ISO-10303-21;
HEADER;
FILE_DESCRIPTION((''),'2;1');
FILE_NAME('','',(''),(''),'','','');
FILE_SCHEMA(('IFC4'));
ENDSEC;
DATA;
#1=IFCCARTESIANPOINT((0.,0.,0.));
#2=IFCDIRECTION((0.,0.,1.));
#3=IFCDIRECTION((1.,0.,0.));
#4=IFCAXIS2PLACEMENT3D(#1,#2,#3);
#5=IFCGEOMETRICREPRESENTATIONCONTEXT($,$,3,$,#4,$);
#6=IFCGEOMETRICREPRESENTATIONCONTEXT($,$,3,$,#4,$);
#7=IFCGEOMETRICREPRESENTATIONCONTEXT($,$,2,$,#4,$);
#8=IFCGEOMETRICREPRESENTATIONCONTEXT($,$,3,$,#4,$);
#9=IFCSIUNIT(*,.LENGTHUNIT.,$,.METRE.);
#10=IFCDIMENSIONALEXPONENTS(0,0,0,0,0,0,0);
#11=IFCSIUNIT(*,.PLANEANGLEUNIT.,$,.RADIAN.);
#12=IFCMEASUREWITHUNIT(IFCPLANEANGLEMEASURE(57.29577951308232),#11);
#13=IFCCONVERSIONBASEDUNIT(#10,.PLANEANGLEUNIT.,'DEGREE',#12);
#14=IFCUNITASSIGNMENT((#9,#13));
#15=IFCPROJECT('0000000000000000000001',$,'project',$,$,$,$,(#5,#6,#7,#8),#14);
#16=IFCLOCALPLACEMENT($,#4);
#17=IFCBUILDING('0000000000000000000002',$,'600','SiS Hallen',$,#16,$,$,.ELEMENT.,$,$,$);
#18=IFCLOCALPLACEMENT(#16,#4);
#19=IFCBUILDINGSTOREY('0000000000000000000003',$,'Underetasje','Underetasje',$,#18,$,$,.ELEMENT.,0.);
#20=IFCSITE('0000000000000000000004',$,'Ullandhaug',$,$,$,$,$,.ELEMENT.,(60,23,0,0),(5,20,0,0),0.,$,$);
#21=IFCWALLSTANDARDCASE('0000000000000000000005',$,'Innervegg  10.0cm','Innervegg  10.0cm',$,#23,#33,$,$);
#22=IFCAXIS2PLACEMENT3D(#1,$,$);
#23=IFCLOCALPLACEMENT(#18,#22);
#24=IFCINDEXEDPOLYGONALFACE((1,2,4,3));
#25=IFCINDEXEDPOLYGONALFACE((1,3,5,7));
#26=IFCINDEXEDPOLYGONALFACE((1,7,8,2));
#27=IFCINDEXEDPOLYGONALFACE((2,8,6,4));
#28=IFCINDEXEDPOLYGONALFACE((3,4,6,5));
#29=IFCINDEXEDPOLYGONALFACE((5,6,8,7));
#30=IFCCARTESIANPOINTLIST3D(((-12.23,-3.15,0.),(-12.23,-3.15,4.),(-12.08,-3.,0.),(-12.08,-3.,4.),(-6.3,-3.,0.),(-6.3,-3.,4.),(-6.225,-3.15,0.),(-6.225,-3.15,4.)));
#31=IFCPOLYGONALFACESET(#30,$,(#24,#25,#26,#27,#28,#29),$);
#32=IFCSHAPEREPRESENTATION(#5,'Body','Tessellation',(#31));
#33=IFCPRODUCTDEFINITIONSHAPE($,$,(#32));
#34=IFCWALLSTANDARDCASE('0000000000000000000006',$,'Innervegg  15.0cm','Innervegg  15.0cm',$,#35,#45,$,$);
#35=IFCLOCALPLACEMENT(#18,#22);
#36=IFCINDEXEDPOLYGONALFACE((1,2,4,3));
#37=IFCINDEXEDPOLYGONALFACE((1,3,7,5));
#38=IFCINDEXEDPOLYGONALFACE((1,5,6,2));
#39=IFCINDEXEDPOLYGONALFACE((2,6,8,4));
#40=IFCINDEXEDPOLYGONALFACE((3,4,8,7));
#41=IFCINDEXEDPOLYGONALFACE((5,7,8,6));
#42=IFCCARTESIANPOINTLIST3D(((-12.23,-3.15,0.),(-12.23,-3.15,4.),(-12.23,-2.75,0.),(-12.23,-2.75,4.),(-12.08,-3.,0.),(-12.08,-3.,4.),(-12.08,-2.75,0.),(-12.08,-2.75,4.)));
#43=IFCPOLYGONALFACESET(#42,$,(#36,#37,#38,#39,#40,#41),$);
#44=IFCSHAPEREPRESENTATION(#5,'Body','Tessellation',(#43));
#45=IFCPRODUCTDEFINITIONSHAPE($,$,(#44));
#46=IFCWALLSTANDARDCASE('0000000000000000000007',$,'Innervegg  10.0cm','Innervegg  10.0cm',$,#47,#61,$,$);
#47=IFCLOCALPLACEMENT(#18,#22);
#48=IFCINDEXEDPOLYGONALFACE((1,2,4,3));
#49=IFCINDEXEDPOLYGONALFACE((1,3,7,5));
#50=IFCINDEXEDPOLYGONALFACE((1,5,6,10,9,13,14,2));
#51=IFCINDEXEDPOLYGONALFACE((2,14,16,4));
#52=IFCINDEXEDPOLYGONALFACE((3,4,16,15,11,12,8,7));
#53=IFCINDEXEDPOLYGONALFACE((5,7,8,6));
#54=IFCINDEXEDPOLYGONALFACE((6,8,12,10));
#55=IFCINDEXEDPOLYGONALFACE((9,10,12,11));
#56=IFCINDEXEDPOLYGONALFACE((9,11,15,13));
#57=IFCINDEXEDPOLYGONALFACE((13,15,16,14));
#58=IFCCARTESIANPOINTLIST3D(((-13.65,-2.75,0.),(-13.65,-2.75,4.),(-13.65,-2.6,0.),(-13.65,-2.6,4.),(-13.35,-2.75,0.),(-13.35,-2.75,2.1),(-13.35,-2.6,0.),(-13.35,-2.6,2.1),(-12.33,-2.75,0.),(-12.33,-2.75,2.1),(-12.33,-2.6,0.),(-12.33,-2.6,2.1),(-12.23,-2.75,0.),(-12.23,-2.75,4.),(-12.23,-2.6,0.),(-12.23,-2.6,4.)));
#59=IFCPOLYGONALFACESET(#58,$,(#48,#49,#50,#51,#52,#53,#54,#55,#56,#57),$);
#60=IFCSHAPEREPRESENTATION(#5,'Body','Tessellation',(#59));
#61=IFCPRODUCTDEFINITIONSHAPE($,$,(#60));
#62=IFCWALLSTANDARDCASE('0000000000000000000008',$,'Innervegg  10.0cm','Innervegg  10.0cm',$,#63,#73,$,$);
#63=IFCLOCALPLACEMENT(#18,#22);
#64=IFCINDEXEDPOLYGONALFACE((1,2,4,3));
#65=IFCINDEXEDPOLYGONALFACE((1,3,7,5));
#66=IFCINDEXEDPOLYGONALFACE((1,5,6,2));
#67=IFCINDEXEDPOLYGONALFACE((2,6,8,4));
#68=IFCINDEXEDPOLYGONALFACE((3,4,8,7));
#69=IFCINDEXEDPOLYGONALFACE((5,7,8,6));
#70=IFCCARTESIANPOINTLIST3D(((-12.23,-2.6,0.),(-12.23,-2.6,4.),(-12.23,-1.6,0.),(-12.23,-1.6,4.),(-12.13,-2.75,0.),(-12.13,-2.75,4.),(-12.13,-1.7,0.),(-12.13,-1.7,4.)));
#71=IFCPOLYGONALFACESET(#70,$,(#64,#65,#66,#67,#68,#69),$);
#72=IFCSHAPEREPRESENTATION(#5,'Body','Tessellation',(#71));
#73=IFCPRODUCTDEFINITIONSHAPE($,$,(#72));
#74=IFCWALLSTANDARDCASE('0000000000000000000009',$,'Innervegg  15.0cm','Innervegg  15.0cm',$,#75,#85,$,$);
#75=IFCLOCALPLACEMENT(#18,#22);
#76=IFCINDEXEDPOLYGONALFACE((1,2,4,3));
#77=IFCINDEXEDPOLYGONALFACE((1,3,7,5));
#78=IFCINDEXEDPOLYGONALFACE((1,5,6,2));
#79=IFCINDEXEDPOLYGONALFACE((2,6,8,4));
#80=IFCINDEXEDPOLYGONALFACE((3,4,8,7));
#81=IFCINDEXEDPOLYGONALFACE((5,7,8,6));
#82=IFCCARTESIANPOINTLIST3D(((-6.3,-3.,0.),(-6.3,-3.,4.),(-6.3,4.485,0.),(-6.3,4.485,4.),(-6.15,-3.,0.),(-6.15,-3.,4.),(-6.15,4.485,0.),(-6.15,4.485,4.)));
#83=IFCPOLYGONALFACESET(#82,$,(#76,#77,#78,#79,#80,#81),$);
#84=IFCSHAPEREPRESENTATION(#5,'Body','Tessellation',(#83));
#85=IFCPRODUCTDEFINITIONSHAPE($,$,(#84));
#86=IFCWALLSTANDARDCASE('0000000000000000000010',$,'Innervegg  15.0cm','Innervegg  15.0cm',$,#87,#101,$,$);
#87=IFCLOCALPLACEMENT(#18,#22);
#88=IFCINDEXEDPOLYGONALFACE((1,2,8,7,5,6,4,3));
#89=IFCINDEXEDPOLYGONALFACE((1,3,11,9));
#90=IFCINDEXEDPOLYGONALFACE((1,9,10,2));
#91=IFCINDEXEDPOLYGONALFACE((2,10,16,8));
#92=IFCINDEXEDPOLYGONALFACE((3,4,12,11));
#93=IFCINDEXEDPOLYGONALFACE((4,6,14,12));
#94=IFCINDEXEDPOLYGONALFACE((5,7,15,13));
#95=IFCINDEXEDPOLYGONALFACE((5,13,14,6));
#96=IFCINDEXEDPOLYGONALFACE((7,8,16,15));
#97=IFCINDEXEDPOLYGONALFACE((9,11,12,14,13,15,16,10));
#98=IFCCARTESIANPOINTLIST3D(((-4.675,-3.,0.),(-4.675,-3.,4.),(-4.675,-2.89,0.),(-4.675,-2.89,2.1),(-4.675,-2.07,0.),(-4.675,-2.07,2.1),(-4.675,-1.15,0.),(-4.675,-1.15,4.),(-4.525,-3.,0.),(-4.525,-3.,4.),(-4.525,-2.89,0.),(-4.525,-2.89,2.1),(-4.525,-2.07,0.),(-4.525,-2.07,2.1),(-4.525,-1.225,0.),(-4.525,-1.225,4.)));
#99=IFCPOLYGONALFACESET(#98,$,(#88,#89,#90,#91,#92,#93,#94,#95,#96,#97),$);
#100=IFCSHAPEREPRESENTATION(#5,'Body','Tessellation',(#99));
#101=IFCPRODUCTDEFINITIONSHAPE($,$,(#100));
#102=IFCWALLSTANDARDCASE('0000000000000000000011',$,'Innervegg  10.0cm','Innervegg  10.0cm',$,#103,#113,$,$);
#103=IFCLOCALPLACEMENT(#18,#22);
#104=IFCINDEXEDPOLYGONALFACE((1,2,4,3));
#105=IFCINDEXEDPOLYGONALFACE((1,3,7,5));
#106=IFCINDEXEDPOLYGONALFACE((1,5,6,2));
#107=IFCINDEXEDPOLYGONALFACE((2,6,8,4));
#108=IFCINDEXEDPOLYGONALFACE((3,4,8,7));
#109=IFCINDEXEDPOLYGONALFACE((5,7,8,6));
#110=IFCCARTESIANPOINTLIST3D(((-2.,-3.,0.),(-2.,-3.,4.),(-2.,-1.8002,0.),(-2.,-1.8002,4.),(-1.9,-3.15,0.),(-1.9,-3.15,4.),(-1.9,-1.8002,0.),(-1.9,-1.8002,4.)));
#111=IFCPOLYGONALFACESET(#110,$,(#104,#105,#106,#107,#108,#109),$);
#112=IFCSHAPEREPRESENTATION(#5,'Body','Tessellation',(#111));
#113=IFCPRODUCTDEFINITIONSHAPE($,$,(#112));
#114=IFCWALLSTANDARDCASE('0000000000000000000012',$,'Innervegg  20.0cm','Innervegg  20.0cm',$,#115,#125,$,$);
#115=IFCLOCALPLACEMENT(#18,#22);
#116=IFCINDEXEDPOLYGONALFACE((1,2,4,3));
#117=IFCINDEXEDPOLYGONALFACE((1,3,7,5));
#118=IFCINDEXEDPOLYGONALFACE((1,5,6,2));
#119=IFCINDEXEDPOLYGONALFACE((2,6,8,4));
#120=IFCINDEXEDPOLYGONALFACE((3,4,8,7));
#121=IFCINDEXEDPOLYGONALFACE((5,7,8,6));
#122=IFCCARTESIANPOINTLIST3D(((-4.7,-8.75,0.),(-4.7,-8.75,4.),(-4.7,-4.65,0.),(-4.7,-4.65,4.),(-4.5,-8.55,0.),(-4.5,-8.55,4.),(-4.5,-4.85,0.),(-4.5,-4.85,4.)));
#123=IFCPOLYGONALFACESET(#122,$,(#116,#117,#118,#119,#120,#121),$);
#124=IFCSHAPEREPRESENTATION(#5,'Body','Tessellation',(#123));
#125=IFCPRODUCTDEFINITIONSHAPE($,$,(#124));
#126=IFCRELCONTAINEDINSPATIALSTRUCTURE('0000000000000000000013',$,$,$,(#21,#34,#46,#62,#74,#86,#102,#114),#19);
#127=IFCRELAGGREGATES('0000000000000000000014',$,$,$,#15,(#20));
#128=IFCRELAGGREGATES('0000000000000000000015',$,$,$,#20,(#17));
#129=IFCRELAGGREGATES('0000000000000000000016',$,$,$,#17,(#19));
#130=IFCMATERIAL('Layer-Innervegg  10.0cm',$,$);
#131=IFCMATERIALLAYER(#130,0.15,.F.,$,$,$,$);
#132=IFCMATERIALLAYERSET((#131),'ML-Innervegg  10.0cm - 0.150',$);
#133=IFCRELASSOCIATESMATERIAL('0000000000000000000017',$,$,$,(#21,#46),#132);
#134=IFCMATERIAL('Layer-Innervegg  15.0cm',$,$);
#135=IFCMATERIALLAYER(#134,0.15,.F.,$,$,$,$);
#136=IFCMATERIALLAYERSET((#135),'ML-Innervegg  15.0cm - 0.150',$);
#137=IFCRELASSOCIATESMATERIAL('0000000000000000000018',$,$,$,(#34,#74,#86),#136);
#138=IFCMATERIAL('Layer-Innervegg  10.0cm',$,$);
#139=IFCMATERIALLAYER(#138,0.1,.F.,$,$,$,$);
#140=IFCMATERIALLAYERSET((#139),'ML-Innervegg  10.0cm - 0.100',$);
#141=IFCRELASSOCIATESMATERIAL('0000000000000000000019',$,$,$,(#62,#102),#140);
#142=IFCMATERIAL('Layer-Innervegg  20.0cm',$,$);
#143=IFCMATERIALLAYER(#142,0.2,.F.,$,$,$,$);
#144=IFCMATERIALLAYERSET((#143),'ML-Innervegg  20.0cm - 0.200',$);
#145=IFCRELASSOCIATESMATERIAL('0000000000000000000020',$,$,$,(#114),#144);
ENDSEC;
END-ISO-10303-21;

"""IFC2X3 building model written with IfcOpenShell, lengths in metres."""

from ifc_helpers import new_model, entity, si_unit, converted_unit, frame, origin_with_axes, place, context, project, spatial, polyline, outline, extrude, material, layer, layer_set, layer_usage, element, save


model = new_model("IFC2X3")

# Units and contexts
context_of_model_1 = context(None, 3, world=origin_with_axes())
context_of_model_2 = context(None, 3, world=origin_with_axes())
context_of_model_3 = context(None, 2, world=origin_with_axes())
context_of_model_4 = context(None, 3, world=origin_with_axes())
ifc_project = project(units=[si_unit("LENGTHUNIT", "METRE"), converted_unit("PLANEANGLEUNIT", "DEGREE", entity("IfcPlaneAngleMeasure", 57.29577951308232), si_unit("PLANEANGLEUNIT", "RADIAN"), dimensions=[0, 0, 0, 0, 0, 0, 0])], contexts=[context_of_model_1, context_of_model_2, context_of_model_3, context_of_model_4])

# Site, building, storey
site = spatial("IfcSite", under=ifc_project, Name="Ullandhaug", CompositionType="ELEMENT", RefLatitude=(60, 23, 0, 0), RefLongitude=(5, 20, 0, 0), RefElevation=0.0)
building_placement = place(None, origin_with_axes())
building = spatial("IfcBuilding", under=site, at=building_placement, Name="600", Description="SiS Hallen", CompositionType="ELEMENT")
storey_placement = place(building_placement, origin_with_axes())
storey = spatial("IfcBuildingStorey", under=building, at=storey_placement, Name="Underetasje", Description="Underetasje", CompositionType="ELEMENT", Elevation=0.0)

# Shared definitions
ifc_material_1 = material(Name="Layer-Innervegg  10.0cm")
ifc_layer_1 = layer(ifc_material_1, 0.1, ventilated=False)
ifc_layer_set_1 = layer_set([ifc_layer_1], Name="ML-Innervegg  10.0cm - 0.100")
ifc_layer_usage_1 = layer_usage(ifc_layer_set_1, "AXIS2", "POSITIVE", 0.0)

# Shared definitions
ifc_material_2 = material(Name="Layer-Innervegg  20.0cm")
ifc_layer_2 = layer(ifc_material_2, 0.2, ventilated=False)
ifc_layer_set_2 = layer_set([ifc_layer_2], Name="ML-Innervegg  20.0cm - 0.200")
ifc_layer_usage_2 = layer_usage(ifc_layer_set_2, "AXIS2", "POSITIVE", 0.0)

# Shared definitions
ifc_material_3 = material(Name="Layer-Innervegg  10.0cm")
ifc_layer_3 = layer(ifc_material_3, 0.15, ventilated=False)
ifc_layer_set_3 = layer_set([ifc_layer_3], Name="ML-Innervegg  10.0cm - 0.150")
ifc_layer_usage_3 = layer_usage(ifc_layer_set_3, "AXIS2", "POSITIVE", 0.0)

# Walls
wall_1_placement = place(storey_placement, frame((-6.3, -3.0, 0.0), z_axis=(0.0, 0.0, 1.0), x_axis=(-1.0, 0.0, 0.0)))
element("IfcWallStandardCase", 1, at=wall_1_placement, inside=storey, material=ifc_layer_usage_3, Name="Innervegg  10.0cm", Description="Innervegg  10.0cm", context=context_of_model_1, shape_type="SweptSolid", body=[
    extrude(outline(polyline([(0.0, 0.0), (5.78, 0.0), (5.93, 0.15), (-0.075, 0.15), (0.0, 0.0)])), frame((0.0, 0.0, 0.0), z_axis=(0.0, 0.0, 1.0), x_axis=(1.0, 0.0, 0.0)), (0.0, 0.0, 1.0), 4.0),
])
ifc_material_4 = material(Name="Layer-Innervegg  15.0cm")
ifc_layer_4 = layer(ifc_material_4, 0.15, ventilated=False)
ifc_layer_set_4 = layer_set([ifc_layer_4], Name="ML-Innervegg  15.0cm - 0.150")
ifc_layer_usage_4 = layer_usage(ifc_layer_set_4, "AXIS2", "POSITIVE", 0.0)
wall_2_placement = place(storey_placement, frame((-12.08, -3.0, 0.0), z_axis=(0.0, 0.0, 1.0), x_axis=(0.0, 1.0, 0.0)))
element("IfcWallStandardCase", 2, at=wall_2_placement, inside=storey, material=ifc_layer_usage_4, Name="Innervegg  15.0cm", Description="Innervegg  15.0cm", context=context_of_model_1, shape_type="SweptSolid", body=[
    extrude(outline(polyline([(0.0, 0.0), (0.25, 0.0), (0.25, 0.15), (-0.15, 0.15), (0.0, 0.0)])), frame((0.0, 0.0, 0.0), z_axis=(0.0, 0.0, 1.0), x_axis=(1.0, 0.0, 0.0)), (0.0, 0.0, 1.0), 4.0),
])

# Wall, opening
wall_3_placement = place(storey_placement, frame((-12.23, -2.6, 0.0), z_axis=(0.0, 0.0, 1.0), x_axis=(-1.0, 0.0, 0.0)))
wall_3 = element("IfcWallStandardCase", 3, at=wall_3_placement, inside=storey, material=ifc_layer_usage_3, Name="Innervegg  10.0cm", Description="Innervegg  10.0cm", context=context_of_model_1, shape_type="SweptSolid", body=[
    extrude(outline(polyline([(0.0, 0.0), (1.42, 0.0), (1.42, 0.15), (0.0, 0.15), (0.0, 0.0)])), frame((0.0, 0.0, 0.0), z_axis=(0.0, 0.0, 1.0), x_axis=(1.0, 0.0, 0.0)), (0.0, 0.0, 1.0), 4.0),
])
opening_1_placement = place(wall_3_placement, frame((0.1, 0.15, 0.0), z_axis=(0.0, 0.0, 1.0), x_axis=(1.0, 0.0, 0.0)))
element("IfcOpeningElement", 4, at=opening_1_placement, cuts=wall_3, context=context_of_model_1, shape_type="SweptSolid", body=[
    extrude(outline(polyline([(0.0, 0.0), (2.1, 0.0), (2.1, 1.02), (0.0, 1.02), (0.0, 0.0)])), frame((0.0, 0.0, 0.0), z_axis=(0.0, 1.0, 0.0), x_axis=(0.0, 0.0, 1.0)), (0.0, 0.0, -1.0), 0.15),
])

# Walls
wall_4_placement = place(storey_placement, frame((-12.13, -2.75, 0.0), z_axis=(0.0, 0.0, 1.0), x_axis=(0.0, 1.0, 0.0)))
element("IfcWallStandardCase", 5, at=wall_4_placement, inside=storey, material=ifc_layer_usage_1, Name="Innervegg  10.0cm", Description="Innervegg  10.0cm", context=context_of_model_1, shape_type="SweptSolid", body=[
    extrude(outline(polyline([(0.0, 0.0), (1.05, 0.0), (1.15, 0.1), (0.15, 0.1), (0.0, 0.0)])), frame((0.0, 0.0, 0.0), z_axis=(0.0, 0.0, 1.0), x_axis=(1.0, 0.0, 0.0)), (0.0, 0.0, 1.0), 4.0),
])
wall_5_placement = place(storey_placement, frame((-6.15, -3.0, 0.0), z_axis=(0.0, 0.0, 1.0), x_axis=(0.0, 1.0, 0.0)))
element("IfcWallStandardCase", 6, at=wall_5_placement, inside=storey, material=ifc_layer_usage_4, Name="Innervegg  15.0cm", Description="Innervegg  15.0cm", context=context_of_model_1, shape_type="SweptSolid", body=[
    extrude(outline(polyline([(0.0, 0.0), (7.485, 0.0), (7.485, 0.15), (0.0, 0.15), (0.0, 0.0)])), frame((0.0, 0.0, 0.0), z_axis=(0.0, 0.0, 1.0), x_axis=(1.0, 0.0, 0.0)), (0.0, 0.0, 1.0), 4.0),
])

# Wall, opening
wall_6_placement = place(storey_placement, frame((-4.525, -3.0, 0.0), z_axis=(0.0, 0.0, 1.0), x_axis=(0.0, 1.0, 0.0)))
wall_6 = element("IfcWallStandardCase", 7, at=wall_6_placement, inside=storey, material=ifc_layer_usage_4, Name="Innervegg  15.0cm", Description="Innervegg  15.0cm", context=context_of_model_1, shape_type="SweptSolid", body=[
    extrude(outline(polyline([(0.0, 0.0), (1.775, 0.0), (1.85, 0.15), (0.0, 0.15), (0.0, 0.0)])), frame((0.0, 0.0, 0.0), z_axis=(0.0, 0.0, 1.0), x_axis=(1.0, 0.0, 0.0)), (0.0, 0.0, 1.0), 4.0),
])
opening_2_placement = place(wall_6_placement, frame((0.11, 0.15, 0.0), z_axis=(0.0, 0.0, 1.0), x_axis=(1.0, 0.0, 0.0)))
element("IfcOpeningElement", 8, at=opening_2_placement, cuts=wall_6, context=context_of_model_1, shape_type="SweptSolid", body=[
    extrude(outline(polyline([(0.0, 0.0), (2.1, 0.0), (2.1, 0.82), (0.0, 0.82), (0.0, 0.0)])), frame((0.0, 0.0, 0.0), z_axis=(0.0, 1.0, 0.0), x_axis=(0.0, 0.0, 1.0)), (0.0, 0.0, -1.0), 0.15),
])

# Walls
wall_7_placement = place(storey_placement, frame((-1.9, -3.15, 0.0), z_axis=(0.0, 0.0, 1.0), x_axis=(0.0, 1.0, 0.0)))
element("IfcWallStandardCase", 9, at=wall_7_placement, inside=storey, material=ifc_layer_usage_1, Name="Innervegg  10.0cm", Description="Innervegg  10.0cm", context=context_of_model_1, shape_type="SweptSolid", body=[
    extrude(outline(polyline([(0.0, 0.0), (1.3498, 0.0), (1.3498, 0.1), (0.15, 0.1), (0.0, 0.0)])), frame((0.0, 0.0, 0.0), z_axis=(0.0, 0.0, 1.0), x_axis=(1.0, 0.0, 0.0)), (0.0, 0.0, 1.0), 4.0),
])
wall_8_placement = place(storey_placement, frame((-4.7, -4.65, 0.0), z_axis=(0.0, 0.0, 1.0), x_axis=(0.0, -1.0, 0.0)))
element("IfcWallStandardCase", 10, at=wall_8_placement, inside=storey, material=ifc_layer_usage_2, Name="Innervegg  20.0cm", Description="Innervegg  20.0cm", context=context_of_model_1, shape_type="SweptSolid", body=[
    extrude(outline(polyline([(0.0, 0.0), (4.1, 0.0), (3.9, 0.2), (0.2, 0.2), (0.0, 0.0)])), frame((0.0, 0.0, 0.0), z_axis=(0.0, 0.0, 1.0), x_axis=(1.0, 0.0, 0.0)), (0.0, 0.0, 1.0), 4.0),
])

save(model, "model.ifc")
